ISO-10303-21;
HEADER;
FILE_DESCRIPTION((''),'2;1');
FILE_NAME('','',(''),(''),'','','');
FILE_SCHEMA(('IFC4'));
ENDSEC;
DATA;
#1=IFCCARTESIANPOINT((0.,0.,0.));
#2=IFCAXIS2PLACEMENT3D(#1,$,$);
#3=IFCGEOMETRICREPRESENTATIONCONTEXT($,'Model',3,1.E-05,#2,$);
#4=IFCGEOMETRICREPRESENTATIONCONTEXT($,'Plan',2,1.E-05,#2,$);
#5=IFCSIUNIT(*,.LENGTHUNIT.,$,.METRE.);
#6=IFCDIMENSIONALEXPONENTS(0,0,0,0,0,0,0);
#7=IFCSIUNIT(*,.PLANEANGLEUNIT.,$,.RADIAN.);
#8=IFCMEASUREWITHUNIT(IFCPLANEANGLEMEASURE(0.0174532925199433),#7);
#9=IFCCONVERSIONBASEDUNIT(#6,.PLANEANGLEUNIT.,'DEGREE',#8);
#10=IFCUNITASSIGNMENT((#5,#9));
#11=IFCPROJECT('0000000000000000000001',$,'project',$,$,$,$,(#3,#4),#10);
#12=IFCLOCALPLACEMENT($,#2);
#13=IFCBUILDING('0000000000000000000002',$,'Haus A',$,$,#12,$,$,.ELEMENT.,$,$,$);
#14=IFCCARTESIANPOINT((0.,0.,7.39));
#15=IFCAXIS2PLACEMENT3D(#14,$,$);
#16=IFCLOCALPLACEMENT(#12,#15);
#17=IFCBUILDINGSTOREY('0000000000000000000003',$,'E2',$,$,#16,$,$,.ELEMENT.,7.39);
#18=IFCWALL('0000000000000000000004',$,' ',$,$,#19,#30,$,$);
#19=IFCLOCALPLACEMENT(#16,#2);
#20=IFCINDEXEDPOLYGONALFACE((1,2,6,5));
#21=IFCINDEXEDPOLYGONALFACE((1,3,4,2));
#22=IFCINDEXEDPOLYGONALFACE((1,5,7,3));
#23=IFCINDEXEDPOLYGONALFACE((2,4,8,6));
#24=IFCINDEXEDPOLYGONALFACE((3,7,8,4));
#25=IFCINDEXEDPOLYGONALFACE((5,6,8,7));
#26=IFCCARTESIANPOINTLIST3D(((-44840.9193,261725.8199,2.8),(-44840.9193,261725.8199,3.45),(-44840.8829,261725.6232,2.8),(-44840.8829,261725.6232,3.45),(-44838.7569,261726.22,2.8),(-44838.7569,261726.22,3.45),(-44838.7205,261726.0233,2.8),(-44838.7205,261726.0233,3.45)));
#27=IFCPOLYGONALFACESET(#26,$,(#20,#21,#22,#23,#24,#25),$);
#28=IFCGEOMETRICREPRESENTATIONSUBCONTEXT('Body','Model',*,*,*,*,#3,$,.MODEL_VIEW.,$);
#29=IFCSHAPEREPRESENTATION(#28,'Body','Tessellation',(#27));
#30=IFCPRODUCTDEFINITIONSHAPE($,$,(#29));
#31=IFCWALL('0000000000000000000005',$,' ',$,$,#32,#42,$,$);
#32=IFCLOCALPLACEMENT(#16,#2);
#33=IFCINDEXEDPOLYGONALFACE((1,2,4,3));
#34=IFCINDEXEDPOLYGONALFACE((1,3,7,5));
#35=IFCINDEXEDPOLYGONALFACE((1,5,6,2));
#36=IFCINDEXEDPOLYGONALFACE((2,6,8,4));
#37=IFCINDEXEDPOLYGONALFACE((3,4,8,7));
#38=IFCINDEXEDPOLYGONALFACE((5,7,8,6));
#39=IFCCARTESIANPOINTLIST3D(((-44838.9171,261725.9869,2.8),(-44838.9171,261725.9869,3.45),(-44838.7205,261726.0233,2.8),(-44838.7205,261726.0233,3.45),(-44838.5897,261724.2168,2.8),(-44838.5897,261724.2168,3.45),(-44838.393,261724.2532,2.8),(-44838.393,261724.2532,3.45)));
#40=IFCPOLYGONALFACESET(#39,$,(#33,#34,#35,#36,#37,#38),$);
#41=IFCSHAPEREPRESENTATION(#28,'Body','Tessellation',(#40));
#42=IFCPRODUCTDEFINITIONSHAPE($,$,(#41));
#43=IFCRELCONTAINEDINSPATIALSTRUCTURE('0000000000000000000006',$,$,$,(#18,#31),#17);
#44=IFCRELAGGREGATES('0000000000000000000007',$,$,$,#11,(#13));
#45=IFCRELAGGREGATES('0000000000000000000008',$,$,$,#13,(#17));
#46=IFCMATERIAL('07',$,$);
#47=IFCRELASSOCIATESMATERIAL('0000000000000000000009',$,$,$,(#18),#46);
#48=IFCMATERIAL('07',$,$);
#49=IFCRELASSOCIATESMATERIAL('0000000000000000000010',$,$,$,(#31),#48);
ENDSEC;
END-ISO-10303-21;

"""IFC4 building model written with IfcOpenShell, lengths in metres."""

from ifc_helpers import new_model, entity, si_unit, converted_unit, frame, frame_2d, origin, origin_with_axes, place, context, subcontext, project, spatial, rectangle, extrude, material, element, save


model = new_model("IFC4")

# Units and contexts
model_context = context("Model", 3, precision=1e-05, world=origin())
plan_context = context("Plan", 2, precision=1e-05, world=origin())
body_context = subcontext(model_context, "Body", "Model", "MODEL_VIEW")
ifc_project = project(units=[si_unit("LENGTHUNIT", "METRE"), converted_unit("PLANEANGLEUNIT", "DEGREE", entity("IfcPlaneAngleMeasure", 0.0174532925199433), si_unit("PLANEANGLEUNIT", "RADIAN"), dimensions=[0, 0, 0, 0, 0, 0, 0])], contexts=[model_context, plan_context])

# Building, storey
building_placement = place(None, origin())
building = spatial("IfcBuilding", under=ifc_project, at=building_placement, Name="Haus A", CompositionType="ELEMENT")
storey_placement = place(building_placement, frame((0.0, 0.0, 7.39)))
storey = spatial("IfcBuildingStorey", under=building, at=storey_placement, Name="E2", CompositionType="ELEMENT", Elevation=7.39)

# Walls
ifc_material_1 = material(Name="07")
wall_1_placement = place(storey_placement, frame((-44840.8829, 261725.6232, 2.8), z_axis=(0.0, 0.0, 1.0), x_axis=(0.983313, 0.18192, 0.0)))
element("IfcWall", 1, at=wall_1_placement, inside=storey, material=ifc_material_1, Name=" ", context=body_context, shape_type="SweptSolid", body=[
    extrude(rectangle(XDim=2.1991, YDim=0.2, at=frame_2d((1.0995, 0.1), x_axis=(1.0, 0.0))), origin_with_axes(), (0.0, 0.0, 1.0), 0.65),
])
ifc_material_2 = material(Name="07")
wall_2_placement = place(storey_placement, frame((-44838.9171, 261725.9869, 2.8), z_axis=(0.0, 0.0, 1.0), x_axis=(0.18192, -0.983313, 0.0)))
element("IfcWall", 2, at=wall_2_placement, inside=storey, material=ifc_material_2, Name=" ", context=body_context, shape_type="SweptSolid", body=[
    extrude(rectangle(XDim=1.8001, YDim=0.2, at=frame_2d((0.9001, 0.1), x_axis=(1.0, 0.0))), origin_with_axes(), (0.0, 0.0, 1.0), 0.65),
])

save(model, "model.ifc")
